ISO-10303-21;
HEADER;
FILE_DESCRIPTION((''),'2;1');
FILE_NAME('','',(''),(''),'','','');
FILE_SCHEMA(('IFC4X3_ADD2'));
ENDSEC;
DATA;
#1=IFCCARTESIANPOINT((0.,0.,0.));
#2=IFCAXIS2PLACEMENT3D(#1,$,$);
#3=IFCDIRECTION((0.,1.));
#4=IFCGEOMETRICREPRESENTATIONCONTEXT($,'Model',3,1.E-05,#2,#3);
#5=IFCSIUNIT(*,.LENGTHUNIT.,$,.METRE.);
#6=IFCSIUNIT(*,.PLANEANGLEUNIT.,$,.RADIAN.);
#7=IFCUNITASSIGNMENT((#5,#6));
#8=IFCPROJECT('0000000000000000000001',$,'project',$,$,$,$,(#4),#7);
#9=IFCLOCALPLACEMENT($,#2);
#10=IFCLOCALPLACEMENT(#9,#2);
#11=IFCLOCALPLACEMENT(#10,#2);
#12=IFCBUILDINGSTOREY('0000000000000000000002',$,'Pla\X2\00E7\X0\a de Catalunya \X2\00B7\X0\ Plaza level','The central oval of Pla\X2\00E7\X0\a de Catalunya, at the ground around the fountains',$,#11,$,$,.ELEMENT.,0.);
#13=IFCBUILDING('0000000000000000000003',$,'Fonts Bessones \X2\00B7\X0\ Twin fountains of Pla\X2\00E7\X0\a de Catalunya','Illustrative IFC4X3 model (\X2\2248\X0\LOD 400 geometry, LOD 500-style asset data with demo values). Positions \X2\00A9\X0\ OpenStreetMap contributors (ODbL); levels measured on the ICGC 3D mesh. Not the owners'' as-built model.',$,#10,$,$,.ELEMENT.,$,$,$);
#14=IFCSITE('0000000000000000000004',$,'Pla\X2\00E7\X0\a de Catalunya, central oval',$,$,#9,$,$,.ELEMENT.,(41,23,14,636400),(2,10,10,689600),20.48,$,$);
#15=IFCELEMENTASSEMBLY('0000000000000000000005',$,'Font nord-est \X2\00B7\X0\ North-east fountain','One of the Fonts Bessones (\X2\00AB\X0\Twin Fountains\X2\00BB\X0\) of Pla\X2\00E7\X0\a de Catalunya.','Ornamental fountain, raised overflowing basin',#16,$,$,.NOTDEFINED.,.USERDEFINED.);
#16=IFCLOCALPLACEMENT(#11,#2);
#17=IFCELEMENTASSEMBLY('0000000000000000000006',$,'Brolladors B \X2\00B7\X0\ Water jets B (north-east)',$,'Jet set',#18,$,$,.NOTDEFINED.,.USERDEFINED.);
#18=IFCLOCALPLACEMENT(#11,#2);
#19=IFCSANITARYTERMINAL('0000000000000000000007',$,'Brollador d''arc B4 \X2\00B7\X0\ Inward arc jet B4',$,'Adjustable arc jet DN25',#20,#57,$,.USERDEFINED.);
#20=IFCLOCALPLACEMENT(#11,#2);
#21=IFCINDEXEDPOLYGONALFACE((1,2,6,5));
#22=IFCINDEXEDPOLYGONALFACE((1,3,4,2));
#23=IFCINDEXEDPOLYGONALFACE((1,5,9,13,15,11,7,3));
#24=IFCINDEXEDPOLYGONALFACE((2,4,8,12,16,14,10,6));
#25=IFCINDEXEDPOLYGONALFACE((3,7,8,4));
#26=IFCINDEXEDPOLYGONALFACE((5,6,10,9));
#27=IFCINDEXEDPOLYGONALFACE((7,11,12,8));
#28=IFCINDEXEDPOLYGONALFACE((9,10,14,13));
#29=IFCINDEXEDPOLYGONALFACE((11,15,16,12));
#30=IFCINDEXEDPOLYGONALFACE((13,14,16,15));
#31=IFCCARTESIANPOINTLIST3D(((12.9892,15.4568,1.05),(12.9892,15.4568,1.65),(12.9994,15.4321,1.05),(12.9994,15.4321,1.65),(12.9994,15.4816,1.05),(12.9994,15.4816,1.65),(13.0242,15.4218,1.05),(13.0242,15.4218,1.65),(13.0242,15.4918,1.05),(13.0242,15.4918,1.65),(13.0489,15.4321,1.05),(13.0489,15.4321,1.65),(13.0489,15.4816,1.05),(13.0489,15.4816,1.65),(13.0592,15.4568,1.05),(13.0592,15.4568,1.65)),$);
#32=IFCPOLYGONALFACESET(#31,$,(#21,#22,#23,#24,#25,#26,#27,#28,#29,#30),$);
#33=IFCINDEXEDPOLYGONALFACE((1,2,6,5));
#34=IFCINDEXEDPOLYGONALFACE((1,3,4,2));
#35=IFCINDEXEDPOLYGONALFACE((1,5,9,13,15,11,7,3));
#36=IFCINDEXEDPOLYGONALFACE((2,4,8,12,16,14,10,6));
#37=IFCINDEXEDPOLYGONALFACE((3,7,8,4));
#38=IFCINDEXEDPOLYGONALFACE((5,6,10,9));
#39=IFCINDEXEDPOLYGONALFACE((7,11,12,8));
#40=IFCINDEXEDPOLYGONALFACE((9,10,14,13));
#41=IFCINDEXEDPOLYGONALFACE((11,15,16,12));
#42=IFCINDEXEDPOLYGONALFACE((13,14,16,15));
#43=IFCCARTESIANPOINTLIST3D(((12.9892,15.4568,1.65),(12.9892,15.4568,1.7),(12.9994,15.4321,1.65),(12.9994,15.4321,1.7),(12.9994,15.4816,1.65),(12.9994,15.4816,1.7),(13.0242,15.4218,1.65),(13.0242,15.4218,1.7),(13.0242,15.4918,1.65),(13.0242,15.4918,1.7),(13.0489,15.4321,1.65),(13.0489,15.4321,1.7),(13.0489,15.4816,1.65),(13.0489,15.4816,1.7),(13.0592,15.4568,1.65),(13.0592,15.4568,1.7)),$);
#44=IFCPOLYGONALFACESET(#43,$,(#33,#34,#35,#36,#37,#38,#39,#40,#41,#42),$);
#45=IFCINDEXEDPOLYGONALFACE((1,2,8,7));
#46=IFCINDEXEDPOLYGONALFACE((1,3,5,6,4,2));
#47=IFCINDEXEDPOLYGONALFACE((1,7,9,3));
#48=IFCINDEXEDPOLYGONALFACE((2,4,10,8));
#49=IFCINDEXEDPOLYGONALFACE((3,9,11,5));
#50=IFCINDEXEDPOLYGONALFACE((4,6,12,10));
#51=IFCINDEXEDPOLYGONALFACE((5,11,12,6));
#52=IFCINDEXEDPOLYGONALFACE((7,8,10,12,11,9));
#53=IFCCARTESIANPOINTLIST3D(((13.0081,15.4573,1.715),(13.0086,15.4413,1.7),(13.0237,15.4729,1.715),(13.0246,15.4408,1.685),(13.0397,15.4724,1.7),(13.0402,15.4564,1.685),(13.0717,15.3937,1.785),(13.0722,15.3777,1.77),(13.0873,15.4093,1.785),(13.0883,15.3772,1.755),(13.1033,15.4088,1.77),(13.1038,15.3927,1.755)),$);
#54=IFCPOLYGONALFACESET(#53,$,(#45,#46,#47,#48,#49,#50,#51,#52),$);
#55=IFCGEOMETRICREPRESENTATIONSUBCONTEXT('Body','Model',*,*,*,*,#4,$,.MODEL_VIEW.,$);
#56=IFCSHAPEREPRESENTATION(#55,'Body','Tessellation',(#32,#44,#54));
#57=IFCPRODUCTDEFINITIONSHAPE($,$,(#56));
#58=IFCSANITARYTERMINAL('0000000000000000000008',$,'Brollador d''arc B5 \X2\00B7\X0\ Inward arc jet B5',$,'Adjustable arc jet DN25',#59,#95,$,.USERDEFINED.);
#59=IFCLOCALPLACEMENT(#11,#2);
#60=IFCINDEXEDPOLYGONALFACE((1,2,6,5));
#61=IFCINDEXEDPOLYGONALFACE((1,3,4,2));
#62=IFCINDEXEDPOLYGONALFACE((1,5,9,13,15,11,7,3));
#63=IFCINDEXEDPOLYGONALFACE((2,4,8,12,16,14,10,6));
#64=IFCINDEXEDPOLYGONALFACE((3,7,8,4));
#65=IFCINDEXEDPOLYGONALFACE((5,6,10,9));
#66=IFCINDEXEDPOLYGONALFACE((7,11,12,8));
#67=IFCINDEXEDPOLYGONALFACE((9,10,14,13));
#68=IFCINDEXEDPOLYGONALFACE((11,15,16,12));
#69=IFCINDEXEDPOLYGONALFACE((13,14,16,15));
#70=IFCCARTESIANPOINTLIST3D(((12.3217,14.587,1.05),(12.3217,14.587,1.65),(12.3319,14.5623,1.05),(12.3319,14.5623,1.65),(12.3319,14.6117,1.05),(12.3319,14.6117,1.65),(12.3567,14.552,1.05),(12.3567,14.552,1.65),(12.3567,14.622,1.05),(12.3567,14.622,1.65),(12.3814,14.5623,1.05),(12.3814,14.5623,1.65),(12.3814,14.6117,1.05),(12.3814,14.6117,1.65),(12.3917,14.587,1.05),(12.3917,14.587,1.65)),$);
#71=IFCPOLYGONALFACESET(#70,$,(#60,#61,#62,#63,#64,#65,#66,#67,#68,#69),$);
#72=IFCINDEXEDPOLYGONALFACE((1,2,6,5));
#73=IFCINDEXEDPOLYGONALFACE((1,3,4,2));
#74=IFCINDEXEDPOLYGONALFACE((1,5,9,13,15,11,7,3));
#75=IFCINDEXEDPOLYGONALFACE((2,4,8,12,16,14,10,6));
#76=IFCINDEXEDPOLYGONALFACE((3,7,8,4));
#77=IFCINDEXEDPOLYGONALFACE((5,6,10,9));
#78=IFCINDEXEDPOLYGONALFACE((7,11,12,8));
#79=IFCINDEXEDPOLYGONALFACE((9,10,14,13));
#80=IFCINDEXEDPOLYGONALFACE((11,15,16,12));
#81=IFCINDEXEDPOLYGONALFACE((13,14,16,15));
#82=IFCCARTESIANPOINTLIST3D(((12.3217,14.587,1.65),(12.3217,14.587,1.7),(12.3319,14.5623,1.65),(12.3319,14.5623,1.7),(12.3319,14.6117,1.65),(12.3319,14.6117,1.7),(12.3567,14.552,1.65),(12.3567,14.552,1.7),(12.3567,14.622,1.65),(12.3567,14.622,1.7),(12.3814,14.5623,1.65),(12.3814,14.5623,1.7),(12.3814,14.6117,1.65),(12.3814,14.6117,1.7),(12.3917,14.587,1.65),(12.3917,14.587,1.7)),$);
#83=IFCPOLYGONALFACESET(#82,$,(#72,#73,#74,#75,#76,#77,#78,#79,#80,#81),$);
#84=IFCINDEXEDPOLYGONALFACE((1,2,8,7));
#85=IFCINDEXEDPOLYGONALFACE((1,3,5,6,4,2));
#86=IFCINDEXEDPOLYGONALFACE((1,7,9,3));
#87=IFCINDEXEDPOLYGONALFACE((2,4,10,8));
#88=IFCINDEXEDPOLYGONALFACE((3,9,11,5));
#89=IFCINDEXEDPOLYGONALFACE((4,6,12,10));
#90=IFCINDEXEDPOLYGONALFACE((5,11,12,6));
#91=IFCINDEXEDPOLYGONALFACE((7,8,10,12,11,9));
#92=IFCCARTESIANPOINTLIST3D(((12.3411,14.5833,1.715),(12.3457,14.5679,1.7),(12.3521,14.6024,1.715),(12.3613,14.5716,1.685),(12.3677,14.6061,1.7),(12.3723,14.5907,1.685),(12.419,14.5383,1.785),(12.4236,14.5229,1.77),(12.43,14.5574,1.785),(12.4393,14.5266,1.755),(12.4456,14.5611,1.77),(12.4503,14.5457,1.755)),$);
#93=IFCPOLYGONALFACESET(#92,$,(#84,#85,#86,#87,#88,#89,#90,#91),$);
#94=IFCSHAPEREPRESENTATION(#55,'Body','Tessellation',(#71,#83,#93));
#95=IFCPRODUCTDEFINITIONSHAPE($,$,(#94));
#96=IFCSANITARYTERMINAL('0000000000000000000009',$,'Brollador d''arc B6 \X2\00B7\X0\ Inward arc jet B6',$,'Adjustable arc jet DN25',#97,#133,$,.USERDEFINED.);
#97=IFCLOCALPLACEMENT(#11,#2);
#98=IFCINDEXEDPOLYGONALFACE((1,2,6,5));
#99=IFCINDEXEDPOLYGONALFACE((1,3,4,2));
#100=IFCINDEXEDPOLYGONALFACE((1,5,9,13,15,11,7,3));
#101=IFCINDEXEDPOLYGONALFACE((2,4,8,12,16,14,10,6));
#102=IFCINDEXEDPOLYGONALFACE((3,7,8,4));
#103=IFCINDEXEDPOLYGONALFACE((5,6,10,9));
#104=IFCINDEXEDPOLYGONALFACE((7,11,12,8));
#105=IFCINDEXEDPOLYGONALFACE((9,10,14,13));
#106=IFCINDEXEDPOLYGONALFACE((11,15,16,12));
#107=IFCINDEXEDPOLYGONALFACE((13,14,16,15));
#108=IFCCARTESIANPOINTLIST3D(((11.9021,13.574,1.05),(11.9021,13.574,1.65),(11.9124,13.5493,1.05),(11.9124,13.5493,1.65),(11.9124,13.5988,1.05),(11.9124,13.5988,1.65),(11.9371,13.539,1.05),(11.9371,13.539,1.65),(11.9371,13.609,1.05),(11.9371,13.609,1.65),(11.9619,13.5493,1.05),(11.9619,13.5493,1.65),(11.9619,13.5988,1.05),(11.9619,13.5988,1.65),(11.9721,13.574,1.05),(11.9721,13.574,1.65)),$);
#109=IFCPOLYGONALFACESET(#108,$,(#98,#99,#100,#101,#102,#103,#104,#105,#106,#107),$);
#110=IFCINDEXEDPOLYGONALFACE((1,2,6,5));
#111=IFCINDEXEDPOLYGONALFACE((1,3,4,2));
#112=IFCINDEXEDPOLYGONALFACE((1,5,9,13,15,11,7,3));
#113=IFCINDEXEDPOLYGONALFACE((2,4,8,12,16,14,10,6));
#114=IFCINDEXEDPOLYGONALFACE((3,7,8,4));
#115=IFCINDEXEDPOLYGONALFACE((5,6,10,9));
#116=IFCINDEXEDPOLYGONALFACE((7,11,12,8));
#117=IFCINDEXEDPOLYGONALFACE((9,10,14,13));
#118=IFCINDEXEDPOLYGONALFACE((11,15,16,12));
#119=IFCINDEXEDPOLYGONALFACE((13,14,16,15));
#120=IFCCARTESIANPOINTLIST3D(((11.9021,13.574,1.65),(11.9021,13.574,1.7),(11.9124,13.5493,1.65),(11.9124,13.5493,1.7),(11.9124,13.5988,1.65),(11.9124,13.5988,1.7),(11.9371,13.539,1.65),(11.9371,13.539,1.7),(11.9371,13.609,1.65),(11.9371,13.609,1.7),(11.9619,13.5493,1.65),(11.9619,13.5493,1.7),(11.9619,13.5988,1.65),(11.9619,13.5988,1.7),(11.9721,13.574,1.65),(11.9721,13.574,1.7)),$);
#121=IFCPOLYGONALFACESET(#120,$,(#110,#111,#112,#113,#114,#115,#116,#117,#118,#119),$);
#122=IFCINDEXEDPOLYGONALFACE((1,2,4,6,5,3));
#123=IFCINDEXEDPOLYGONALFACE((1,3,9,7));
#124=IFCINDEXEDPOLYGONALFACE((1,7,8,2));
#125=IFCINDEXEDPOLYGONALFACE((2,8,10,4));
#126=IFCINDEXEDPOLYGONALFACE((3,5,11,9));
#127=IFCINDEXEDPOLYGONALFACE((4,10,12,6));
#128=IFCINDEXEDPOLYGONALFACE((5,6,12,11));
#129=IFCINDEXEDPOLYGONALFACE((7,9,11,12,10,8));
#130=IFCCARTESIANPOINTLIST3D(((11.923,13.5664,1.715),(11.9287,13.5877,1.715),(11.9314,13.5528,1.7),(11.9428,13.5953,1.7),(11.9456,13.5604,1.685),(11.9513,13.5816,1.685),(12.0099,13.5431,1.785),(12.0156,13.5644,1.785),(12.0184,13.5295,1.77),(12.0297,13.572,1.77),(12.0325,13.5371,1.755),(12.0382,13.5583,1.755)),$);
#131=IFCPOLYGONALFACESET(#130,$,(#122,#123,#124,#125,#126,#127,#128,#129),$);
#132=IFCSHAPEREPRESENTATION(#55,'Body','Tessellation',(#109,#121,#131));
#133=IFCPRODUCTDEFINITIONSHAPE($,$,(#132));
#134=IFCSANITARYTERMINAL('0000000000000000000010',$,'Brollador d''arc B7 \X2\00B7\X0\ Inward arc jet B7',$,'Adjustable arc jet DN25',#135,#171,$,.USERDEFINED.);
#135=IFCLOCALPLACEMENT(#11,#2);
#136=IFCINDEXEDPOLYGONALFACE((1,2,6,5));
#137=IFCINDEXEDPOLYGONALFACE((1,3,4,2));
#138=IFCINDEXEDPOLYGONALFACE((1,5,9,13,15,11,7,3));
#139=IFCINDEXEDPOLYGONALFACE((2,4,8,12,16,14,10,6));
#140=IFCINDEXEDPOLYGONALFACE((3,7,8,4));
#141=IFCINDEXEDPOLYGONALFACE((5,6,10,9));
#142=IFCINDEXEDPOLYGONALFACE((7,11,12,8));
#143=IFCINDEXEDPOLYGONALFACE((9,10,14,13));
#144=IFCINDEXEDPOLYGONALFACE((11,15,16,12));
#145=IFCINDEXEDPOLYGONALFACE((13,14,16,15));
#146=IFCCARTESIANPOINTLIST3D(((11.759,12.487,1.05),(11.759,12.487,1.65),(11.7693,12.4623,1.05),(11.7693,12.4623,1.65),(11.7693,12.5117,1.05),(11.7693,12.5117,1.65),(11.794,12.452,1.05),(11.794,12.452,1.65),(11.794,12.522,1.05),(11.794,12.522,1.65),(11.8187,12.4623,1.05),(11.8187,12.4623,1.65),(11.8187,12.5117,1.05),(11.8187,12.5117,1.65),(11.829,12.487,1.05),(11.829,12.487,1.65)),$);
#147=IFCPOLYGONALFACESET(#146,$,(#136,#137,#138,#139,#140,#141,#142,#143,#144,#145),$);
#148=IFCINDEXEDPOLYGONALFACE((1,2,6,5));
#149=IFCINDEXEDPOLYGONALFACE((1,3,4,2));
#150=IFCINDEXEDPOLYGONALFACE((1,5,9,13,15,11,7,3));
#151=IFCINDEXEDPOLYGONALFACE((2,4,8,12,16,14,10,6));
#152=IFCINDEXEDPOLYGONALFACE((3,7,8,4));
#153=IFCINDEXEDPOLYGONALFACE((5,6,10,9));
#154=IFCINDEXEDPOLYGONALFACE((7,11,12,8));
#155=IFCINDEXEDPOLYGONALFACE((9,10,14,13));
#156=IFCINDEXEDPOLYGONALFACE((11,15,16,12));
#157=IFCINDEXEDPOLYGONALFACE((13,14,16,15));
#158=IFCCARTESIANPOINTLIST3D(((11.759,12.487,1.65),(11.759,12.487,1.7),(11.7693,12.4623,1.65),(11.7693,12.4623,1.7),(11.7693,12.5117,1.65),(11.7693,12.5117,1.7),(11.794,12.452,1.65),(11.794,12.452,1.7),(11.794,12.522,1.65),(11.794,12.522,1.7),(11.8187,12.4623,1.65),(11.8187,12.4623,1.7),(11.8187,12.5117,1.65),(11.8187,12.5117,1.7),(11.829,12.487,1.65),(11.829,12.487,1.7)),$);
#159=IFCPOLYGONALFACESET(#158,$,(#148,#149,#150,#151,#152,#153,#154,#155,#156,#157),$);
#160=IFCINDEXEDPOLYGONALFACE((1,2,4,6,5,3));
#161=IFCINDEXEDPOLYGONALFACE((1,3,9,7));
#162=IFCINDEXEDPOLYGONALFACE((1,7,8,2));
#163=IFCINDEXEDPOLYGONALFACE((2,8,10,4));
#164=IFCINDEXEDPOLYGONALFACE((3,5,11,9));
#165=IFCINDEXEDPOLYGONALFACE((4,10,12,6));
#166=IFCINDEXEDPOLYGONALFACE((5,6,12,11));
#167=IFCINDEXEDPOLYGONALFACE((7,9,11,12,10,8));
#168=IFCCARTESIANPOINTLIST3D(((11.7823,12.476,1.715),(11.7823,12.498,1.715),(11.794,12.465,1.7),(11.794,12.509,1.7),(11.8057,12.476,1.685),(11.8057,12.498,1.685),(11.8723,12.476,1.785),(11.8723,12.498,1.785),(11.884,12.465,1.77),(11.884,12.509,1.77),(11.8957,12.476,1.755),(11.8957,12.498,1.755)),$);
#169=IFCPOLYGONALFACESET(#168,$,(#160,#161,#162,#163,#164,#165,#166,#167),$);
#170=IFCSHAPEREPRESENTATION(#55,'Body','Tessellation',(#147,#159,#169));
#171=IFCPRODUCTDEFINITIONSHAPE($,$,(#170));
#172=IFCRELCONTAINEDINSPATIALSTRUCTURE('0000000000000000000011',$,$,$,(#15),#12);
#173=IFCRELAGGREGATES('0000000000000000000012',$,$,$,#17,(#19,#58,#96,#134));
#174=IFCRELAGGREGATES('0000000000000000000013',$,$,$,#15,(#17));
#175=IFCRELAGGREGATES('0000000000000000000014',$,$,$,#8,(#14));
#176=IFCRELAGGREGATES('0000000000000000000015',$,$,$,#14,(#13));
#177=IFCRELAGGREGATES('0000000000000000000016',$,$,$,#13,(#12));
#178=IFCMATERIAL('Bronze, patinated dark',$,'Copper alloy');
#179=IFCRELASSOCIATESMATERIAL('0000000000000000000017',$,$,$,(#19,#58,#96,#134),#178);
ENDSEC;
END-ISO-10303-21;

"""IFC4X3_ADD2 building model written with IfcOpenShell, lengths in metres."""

from ifc_helpers import new_model, si_unit, direction, frame, origin, place, context, subcontext, project, spatial, polyline, outline, extrude, material, element, aggregate, save


model = new_model("IFC4X3_ADD2")

# Units and contexts
model_context = context("Model", 3, precision=1e-05, world=origin(), true_north=direction((0.0, 1.0)))
body_context = subcontext(model_context, "Body", "Model", "MODEL_VIEW")
ifc_project = project(units=[si_unit("LENGTHUNIT", "METRE"), si_unit("PLANEANGLEUNIT", "RADIAN")], contexts=[model_context])

# Site, building, storey
site_placement = place(None, origin())
site = spatial("IfcSite", under=ifc_project, at=site_placement, Name="Plaça de Catalunya, central oval", CompositionType="ELEMENT", RefLatitude=(41, 23, 14, 636400), RefLongitude=(2, 10, 10, 689600), RefElevation=20.48)
building_placement = place(site_placement, origin())
building = spatial("IfcBuilding", under=site, at=building_placement, Name="Fonts Bessones · Twin fountains of Plaça de Catalunya", Description="Illustrative IFC4X3 model (≈LOD 400 geometry, LOD 500-style asset data with demo values). Positions © OpenStreetMap contributors (ODbL); levels measured on the ICGC 3D mesh. Not the owners' as-built model.", CompositionType="ELEMENT")
storey_placement = place(building_placement, origin())
storey = spatial("IfcBuildingStorey", under=building, at=storey_placement, Name="Plaça de Catalunya · Plaza level", Description="The central oval of Plaça de Catalunya, at the ground around the fountains", CompositionType="ELEMENT", Elevation=0.0)

# Element assemblies, sanitary terminals
assembly_1_placement = place(building_placement, origin())
assembly_1 = element("IfcElementAssembly", 1, at=assembly_1_placement, inside=storey, Name="Font nord-est · North-east fountain", Description="One of the Fonts Bessones («Twin Fountains») of Plaça de Catalunya.", ObjectType="Ornamental fountain, raised overflowing basin", AssemblyPlace="NOTDEFINED", PredefinedType="USERDEFINED")
assembly_2_placement = place(building_placement, origin())
assembly_2 = element("IfcElementAssembly", 2, at=assembly_2_placement, Name="Brolladors B · Water jets B (north-east)", ObjectType="Jet set", AssemblyPlace="NOTDEFINED", PredefinedType="USERDEFINED")
ifc_material_1 = material(Name="Bronze, patinated dark", Category="Copper alloy")
sanitary_terminal_1_placement = place(building_placement, origin())
sanitary_terminal_1 = element("IfcSanitaryTerminal", 3, at=sanitary_terminal_1_placement, material=ifc_material_1, Name="Brollador d'arc B4 · Inward arc jet B4", ObjectType="Adjustable arc jet DN25", PredefinedType="USERDEFINED", context=body_context, shape_type="SweptSolid", body=[
    extrude(outline(polyline([(13.0592, 15.4568), (13.0489, 15.4816), (13.0242, 15.4918), (12.9994, 15.4816), (12.9892, 15.4568), (12.9994, 15.4321), (13.0242, 15.4218), (13.0489, 15.4321), (13.0592, 15.4568)])), frame((0.0, 0.0, 1.05)), (0.0, 0.0, 1.0), 0.6),
    extrude(outline(polyline([(13.0592, 15.4568), (13.0489, 15.4816), (13.0242, 15.4918), (12.9994, 15.4816), (12.9892, 15.4568), (12.9994, 15.4321), (13.0242, 15.4218), (13.0489, 15.4321), (13.0592, 15.4568)])), frame((0.0, 0.0, 1.65)), (0.0, 0.0, 1.0), 0.05),
    extrude(outline(polyline([(0.022, 0.0), (0.011, 0.0191), (-0.011, 0.0191), (-0.022, 0.0), (-0.011, -0.0191), (0.011, -0.0191), (0.022, 0.0)])), frame((13.0242, 15.4568, 1.7), z_axis=(0.558156, -0.558156, 0.613941), x_axis=(-0.707107, -0.707107, 0.0)), (0.0, 0.0, 1.0), 0.114),
])
sanitary_terminal_2_placement = place(building_placement, origin())
sanitary_terminal_2 = element("IfcSanitaryTerminal", 4, at=sanitary_terminal_2_placement, material=ifc_material_1, Name="Brollador d'arc B5 · Inward arc jet B5", ObjectType="Adjustable arc jet DN25", PredefinedType="USERDEFINED", context=body_context, shape_type="SweptSolid", body=[
    extrude(outline(polyline([(12.3917, 14.587), (12.3814, 14.6117), (12.3567, 14.622), (12.3319, 14.6117), (12.3217, 14.587), (12.3319, 14.5623), (12.3567, 14.552), (12.3814, 14.5623), (12.3917, 14.587)])), frame((0.0, 0.0, 1.05)), (0.0, 0.0, 1.0), 0.6),
    extrude(outline(polyline([(12.3917, 14.587), (12.3814, 14.6117), (12.3567, 14.622), (12.3319, 14.6117), (12.3217, 14.587), (12.3319, 14.5623), (12.3567, 14.552), (12.3814, 14.5623), (12.3917, 14.587)])), frame((0.0, 0.0, 1.65)), (0.0, 0.0, 1.0), 0.05),
    extrude(outline(polyline([(0.022, 0.0), (0.011, 0.0191), (-0.011, 0.0191), (-0.022, 0.0), (-0.011, -0.0191), (0.011, -0.0191), (0.022, 0.0)])), frame((12.3567, 14.587, 1.7), z_axis=(0.683599, -0.394676, 0.613941), x_axis=(-0.5, -0.866025, 0.0)), (0.0, 0.0, 1.0), 0.114),
])
sanitary_terminal_3_placement = place(building_placement, origin())
sanitary_terminal_3 = element("IfcSanitaryTerminal", 5, at=sanitary_terminal_3_placement, material=ifc_material_1, Name="Brollador d'arc B6 · Inward arc jet B6", ObjectType="Adjustable arc jet DN25", PredefinedType="USERDEFINED", context=body_context, shape_type="SweptSolid", body=[
    extrude(outline(polyline([(11.9721, 13.574), (11.9619, 13.5988), (11.9371, 13.609), (11.9124, 13.5988), (11.9021, 13.574), (11.9124, 13.5493), (11.9371, 13.539), (11.9619, 13.5493), (11.9721, 13.574)])), frame((0.0, 0.0, 1.05)), (0.0, 0.0, 1.0), 0.6),
    extrude(outline(polyline([(11.9721, 13.574), (11.9619, 13.5988), (11.9371, 13.609), (11.9124, 13.5988), (11.9021, 13.574), (11.9124, 13.5493), (11.9371, 13.539), (11.9619, 13.5493), (11.9721, 13.574)])), frame((0.0, 0.0, 1.65)), (0.0, 0.0, 1.0), 0.05),
    extrude(outline(polyline([(0.022, 0.0), (0.011, 0.0191), (-0.011, 0.0191), (-0.022, 0.0), (-0.011, -0.0191), (0.011, -0.0191), (0.022, 0.0)])), frame((11.9371, 13.574, 1.7), z_axis=(0.762456, -0.204299, 0.613941), x_axis=(-0.258819, -0.965926, 0.0)), (0.0, 0.0, 1.0), 0.114),
])
sanitary_terminal_4_placement = place(building_placement, origin())
sanitary_terminal_4 = element("IfcSanitaryTerminal", 6, at=sanitary_terminal_4_placement, material=ifc_material_1, Name="Brollador d'arc B7 · Inward arc jet B7", ObjectType="Adjustable arc jet DN25", PredefinedType="USERDEFINED", context=body_context, shape_type="SweptSolid", body=[
    extrude(outline(polyline([(11.829, 12.487), (11.8187, 12.5117), (11.794, 12.522), (11.7693, 12.5117), (11.759, 12.487), (11.7693, 12.4623), (11.794, 12.452), (11.8187, 12.4623), (11.829, 12.487)])), frame((0.0, 0.0, 1.05)), (0.0, 0.0, 1.0), 0.6),
    extrude(outline(polyline([(11.829, 12.487), (11.8187, 12.5117), (11.794, 12.522), (11.7693, 12.5117), (11.759, 12.487), (11.7693, 12.4623), (11.794, 12.452), (11.8187, 12.4623), (11.829, 12.487)])), frame((0.0, 0.0, 1.65)), (0.0, 0.0, 1.0), 0.05),
    extrude(outline(polyline([(0.022, 0.0), (0.011, 0.0191), (-0.011, 0.0191), (-0.022, 0.0), (-0.011, -0.0191), (0.011, -0.0191), (0.022, 0.0)])), frame((11.794, 12.487, 1.7), z_axis=(0.789352, 0.0, 0.613941), x_axis=(0.0, -1.0, 0.0)), (0.0, 0.0, 1.0), 0.114),
])
aggregate(assembly_2, [sanitary_terminal_1, sanitary_terminal_2, sanitary_terminal_3, sanitary_terminal_4])
aggregate(assembly_1, [assembly_2])

save(model, "model.ifc")
